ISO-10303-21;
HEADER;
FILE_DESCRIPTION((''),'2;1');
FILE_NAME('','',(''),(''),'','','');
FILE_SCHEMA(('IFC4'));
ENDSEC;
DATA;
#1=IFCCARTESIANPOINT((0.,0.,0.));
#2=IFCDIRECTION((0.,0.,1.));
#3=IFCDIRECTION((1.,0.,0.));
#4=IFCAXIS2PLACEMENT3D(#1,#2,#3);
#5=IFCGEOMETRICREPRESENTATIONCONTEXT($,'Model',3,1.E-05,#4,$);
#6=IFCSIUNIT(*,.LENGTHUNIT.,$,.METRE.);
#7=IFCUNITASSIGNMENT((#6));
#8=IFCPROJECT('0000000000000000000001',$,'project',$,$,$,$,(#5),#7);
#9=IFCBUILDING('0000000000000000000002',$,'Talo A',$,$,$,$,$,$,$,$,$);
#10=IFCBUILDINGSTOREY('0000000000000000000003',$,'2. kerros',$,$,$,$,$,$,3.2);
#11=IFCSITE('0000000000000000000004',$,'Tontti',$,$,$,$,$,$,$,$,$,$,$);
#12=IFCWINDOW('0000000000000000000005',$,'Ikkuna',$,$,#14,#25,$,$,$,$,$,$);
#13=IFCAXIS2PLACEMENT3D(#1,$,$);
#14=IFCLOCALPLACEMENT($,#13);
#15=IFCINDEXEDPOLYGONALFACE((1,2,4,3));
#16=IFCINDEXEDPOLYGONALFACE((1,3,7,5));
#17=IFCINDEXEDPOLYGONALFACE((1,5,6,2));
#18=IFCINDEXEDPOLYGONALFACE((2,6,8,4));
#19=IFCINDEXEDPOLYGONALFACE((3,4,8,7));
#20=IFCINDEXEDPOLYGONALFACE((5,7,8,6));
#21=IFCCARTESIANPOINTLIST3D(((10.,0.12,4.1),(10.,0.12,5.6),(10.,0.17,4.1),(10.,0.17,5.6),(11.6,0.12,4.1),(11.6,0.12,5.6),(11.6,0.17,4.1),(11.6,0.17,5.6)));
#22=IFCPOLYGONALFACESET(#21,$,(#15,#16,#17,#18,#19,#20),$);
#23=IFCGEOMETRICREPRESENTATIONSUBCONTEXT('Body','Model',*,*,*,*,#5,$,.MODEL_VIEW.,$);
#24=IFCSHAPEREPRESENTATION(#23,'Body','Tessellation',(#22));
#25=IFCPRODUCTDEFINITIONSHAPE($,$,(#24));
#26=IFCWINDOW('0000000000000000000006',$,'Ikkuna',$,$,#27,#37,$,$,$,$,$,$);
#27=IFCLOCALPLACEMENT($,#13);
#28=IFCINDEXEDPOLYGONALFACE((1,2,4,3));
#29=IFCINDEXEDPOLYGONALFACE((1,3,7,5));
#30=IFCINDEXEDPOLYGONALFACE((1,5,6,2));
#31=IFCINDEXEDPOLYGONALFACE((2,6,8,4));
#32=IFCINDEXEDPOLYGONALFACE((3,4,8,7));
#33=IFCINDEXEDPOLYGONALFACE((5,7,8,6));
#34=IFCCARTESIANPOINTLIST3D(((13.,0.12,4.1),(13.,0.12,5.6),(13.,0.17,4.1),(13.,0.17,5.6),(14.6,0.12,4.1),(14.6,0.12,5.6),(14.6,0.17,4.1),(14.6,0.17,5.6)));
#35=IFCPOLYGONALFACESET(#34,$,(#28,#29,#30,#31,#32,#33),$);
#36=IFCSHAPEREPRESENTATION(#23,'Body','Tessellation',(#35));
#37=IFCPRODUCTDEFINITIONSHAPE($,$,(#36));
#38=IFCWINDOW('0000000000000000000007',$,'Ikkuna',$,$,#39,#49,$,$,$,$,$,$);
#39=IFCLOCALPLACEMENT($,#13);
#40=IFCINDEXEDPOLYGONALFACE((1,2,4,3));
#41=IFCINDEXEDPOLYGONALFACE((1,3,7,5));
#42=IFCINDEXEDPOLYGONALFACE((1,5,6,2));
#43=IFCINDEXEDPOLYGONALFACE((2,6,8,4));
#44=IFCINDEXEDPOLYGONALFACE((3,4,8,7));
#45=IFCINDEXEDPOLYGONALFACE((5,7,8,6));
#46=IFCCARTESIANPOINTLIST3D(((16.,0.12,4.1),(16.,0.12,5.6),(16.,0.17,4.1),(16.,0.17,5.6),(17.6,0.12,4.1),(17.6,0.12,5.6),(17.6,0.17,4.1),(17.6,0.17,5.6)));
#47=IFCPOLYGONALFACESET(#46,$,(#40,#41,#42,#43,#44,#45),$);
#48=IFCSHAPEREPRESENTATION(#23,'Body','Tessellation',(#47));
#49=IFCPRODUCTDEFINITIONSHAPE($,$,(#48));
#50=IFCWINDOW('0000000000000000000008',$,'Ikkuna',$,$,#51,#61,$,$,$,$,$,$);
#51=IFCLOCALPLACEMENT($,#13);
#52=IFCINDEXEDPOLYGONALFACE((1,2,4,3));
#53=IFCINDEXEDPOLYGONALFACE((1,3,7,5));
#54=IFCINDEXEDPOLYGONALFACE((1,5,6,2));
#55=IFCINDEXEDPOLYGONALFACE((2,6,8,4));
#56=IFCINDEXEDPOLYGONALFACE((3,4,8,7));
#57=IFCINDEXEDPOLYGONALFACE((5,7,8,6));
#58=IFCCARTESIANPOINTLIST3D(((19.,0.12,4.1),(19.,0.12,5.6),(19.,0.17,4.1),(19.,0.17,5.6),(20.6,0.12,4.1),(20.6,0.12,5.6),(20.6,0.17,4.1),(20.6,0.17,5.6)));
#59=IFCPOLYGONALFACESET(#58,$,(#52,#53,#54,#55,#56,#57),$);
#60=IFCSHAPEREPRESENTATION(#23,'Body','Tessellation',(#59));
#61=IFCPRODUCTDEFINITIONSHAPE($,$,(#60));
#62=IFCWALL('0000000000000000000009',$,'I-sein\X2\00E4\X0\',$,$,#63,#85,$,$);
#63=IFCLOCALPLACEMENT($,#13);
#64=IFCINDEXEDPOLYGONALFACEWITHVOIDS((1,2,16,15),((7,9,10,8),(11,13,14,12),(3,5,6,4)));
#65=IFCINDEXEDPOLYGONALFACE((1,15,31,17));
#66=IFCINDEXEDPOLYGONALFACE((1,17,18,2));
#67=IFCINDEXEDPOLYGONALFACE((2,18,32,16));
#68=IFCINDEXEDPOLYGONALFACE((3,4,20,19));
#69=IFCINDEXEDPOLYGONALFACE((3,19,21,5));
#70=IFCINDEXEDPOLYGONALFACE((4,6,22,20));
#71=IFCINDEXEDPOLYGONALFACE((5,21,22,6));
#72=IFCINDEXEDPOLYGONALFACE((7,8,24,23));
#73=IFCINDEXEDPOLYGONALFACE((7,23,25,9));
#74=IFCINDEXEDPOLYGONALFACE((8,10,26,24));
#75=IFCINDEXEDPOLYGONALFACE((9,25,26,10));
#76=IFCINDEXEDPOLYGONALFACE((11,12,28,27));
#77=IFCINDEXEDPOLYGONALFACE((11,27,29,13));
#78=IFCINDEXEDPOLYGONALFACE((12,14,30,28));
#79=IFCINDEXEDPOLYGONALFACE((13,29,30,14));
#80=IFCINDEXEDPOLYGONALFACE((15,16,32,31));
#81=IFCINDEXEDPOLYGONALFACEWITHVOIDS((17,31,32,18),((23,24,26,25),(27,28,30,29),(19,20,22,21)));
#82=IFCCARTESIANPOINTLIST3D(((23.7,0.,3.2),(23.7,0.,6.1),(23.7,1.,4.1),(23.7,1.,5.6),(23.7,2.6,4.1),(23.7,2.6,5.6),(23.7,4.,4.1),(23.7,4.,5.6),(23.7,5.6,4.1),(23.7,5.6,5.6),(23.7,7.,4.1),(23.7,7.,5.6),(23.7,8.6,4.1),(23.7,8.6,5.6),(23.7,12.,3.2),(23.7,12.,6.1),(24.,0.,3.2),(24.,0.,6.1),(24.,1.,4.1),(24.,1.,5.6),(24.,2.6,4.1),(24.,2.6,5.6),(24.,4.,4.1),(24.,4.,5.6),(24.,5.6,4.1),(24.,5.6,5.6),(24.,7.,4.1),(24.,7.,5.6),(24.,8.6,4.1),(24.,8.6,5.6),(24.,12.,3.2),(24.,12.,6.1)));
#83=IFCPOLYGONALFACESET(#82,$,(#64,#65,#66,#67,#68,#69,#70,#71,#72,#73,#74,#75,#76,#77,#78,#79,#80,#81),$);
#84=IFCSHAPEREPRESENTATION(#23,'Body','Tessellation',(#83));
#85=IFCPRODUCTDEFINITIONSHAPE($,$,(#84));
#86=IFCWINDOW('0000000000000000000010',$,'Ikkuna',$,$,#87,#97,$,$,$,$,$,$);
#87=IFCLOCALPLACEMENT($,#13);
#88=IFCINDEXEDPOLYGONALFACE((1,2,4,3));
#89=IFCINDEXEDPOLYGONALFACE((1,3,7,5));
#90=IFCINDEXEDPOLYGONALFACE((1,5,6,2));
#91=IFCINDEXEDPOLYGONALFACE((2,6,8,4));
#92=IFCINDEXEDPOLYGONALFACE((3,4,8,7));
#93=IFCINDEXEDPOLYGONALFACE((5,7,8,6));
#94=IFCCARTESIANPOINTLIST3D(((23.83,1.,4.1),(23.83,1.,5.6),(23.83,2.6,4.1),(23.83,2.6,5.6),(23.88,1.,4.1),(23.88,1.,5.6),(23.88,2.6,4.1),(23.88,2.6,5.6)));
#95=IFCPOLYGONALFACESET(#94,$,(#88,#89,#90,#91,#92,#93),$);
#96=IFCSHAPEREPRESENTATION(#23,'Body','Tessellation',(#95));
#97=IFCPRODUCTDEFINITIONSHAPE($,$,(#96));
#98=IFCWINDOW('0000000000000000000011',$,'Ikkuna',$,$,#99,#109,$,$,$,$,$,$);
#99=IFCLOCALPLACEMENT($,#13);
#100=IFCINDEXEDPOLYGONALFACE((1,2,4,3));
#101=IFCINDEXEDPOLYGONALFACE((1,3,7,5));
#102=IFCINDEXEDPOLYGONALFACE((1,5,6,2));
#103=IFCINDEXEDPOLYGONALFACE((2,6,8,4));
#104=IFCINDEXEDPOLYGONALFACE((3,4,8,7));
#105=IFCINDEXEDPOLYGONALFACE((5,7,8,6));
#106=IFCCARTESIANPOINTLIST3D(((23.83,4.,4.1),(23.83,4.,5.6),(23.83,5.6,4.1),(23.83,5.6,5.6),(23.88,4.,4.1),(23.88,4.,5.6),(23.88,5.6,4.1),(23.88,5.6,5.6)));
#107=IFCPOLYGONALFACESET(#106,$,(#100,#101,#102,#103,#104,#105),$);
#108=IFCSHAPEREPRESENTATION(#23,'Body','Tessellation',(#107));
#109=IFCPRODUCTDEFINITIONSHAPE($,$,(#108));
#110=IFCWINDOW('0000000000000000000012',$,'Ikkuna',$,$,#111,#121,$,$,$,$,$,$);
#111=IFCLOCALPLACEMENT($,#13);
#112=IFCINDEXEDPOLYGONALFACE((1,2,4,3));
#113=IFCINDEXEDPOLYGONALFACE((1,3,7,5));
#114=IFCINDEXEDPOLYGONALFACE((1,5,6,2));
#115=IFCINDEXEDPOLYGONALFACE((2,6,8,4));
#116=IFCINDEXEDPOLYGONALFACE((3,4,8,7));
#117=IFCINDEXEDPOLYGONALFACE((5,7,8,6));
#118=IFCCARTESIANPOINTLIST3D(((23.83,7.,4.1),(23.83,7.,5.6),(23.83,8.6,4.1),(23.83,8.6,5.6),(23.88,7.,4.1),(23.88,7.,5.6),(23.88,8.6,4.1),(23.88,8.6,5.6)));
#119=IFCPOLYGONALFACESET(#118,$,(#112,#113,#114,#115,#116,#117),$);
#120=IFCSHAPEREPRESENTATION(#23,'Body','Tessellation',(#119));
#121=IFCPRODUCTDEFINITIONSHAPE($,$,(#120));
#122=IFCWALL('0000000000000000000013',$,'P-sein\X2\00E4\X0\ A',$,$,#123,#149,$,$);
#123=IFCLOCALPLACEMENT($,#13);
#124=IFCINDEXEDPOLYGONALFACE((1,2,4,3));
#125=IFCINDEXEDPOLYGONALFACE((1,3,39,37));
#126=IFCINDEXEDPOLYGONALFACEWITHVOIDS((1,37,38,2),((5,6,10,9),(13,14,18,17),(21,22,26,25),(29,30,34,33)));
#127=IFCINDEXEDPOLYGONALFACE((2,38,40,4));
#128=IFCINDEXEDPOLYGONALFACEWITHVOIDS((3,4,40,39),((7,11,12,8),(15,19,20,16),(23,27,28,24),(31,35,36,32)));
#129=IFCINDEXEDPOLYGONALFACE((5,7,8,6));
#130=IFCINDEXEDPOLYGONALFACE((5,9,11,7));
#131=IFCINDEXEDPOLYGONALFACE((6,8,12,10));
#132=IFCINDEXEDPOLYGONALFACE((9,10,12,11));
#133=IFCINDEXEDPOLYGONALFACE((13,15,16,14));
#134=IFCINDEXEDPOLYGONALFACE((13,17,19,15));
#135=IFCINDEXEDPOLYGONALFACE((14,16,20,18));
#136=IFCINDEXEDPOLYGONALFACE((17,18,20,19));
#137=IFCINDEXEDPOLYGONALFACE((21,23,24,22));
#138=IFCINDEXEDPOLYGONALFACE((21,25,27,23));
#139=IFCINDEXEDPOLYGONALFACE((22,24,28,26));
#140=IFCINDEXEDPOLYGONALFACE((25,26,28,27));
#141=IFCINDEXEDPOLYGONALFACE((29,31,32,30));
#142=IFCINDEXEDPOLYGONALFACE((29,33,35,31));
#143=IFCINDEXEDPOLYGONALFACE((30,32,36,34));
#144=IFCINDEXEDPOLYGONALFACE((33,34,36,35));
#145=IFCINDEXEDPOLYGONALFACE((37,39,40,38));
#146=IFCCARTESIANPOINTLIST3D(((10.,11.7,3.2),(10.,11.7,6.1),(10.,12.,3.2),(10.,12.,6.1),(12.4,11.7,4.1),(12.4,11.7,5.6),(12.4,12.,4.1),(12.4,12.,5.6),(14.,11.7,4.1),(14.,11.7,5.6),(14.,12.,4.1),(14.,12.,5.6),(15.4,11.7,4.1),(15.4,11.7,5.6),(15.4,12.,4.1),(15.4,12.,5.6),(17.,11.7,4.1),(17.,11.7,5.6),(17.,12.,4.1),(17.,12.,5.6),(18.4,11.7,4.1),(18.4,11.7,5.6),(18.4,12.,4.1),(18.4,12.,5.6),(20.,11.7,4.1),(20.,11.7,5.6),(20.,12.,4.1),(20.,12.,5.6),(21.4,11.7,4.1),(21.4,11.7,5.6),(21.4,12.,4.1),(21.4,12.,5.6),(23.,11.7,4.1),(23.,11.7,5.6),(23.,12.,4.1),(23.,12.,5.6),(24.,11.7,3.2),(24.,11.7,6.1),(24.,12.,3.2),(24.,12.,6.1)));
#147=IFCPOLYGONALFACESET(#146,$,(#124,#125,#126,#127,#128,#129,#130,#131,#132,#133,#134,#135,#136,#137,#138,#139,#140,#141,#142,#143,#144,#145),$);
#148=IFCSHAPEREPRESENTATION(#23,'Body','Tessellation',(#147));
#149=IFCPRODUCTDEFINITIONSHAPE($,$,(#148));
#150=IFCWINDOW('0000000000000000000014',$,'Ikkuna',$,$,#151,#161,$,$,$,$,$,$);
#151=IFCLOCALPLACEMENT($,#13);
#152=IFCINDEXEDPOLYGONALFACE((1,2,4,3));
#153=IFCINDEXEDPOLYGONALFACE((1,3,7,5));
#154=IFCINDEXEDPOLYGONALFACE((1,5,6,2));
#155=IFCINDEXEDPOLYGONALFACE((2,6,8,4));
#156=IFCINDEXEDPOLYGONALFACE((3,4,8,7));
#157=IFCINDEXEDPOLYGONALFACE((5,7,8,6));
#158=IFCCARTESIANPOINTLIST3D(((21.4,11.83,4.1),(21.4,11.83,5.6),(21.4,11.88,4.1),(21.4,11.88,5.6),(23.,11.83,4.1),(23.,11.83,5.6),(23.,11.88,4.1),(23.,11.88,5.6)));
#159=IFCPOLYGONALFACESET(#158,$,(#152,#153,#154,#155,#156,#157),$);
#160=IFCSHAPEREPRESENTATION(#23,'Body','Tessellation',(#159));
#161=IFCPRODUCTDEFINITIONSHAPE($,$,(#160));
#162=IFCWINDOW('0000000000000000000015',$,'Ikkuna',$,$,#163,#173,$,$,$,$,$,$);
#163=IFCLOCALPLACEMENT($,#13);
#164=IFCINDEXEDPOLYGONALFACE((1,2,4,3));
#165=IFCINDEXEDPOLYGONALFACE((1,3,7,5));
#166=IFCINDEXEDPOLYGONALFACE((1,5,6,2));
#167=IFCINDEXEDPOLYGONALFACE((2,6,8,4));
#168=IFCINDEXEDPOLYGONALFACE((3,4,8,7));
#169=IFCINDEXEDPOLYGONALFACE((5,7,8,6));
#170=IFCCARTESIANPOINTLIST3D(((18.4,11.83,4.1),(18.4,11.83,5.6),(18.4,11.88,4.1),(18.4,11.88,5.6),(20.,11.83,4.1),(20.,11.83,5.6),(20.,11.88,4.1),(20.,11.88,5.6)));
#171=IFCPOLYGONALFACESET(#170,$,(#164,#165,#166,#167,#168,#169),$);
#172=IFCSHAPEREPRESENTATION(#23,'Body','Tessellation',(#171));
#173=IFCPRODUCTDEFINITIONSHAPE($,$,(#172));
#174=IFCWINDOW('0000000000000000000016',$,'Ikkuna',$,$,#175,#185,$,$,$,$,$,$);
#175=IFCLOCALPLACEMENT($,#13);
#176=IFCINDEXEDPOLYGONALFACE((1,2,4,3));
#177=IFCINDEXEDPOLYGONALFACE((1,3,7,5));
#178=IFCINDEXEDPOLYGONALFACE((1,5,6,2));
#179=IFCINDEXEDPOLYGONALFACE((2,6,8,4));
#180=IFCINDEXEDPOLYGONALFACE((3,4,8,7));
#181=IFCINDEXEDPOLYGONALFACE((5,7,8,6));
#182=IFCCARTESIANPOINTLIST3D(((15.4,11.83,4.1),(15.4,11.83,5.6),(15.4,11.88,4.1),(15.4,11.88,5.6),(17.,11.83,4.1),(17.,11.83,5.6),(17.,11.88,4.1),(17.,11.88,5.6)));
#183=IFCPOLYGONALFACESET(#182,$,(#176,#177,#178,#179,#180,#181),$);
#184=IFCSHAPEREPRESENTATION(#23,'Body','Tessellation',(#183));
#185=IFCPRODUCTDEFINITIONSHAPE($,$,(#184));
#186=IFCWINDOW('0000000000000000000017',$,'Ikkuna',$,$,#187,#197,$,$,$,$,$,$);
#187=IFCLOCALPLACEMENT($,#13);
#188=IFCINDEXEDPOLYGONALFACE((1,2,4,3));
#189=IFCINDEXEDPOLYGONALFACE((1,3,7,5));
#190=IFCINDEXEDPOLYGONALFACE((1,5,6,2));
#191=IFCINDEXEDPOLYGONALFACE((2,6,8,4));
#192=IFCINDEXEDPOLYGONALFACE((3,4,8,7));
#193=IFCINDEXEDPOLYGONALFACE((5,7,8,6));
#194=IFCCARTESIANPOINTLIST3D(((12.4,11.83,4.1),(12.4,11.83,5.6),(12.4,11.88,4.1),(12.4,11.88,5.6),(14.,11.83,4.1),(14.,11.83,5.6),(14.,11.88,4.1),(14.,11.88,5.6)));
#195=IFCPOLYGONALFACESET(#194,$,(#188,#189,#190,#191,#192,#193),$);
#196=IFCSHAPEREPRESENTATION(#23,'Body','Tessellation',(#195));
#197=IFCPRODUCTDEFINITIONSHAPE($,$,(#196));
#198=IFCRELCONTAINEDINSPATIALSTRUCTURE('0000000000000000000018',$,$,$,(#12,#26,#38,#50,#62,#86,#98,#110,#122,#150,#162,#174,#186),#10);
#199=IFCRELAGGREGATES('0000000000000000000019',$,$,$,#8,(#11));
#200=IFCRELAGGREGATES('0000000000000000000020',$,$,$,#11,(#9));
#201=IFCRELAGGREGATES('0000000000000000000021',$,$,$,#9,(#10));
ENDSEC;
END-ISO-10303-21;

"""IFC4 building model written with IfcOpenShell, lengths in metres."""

from ifc_helpers import new_model, si_unit, frame, origin_with_axes, place, context, subcontext, project, spatial, indexed_curve, outline, extrude, element, save


model = new_model("IFC4")

# Units and contexts
model_context = context("Model", 3, precision=1e-05, world=origin_with_axes())
body_context = subcontext(model_context, "Body", "Model", "MODEL_VIEW")
ifc_project = project(units=[si_unit("LENGTHUNIT", "METRE")], contexts=[model_context])

# Site, building, storey
site = spatial("IfcSite", under=ifc_project, Name="Tontti")
building = spatial("IfcBuilding", under=site, Name="Talo A")
storey = spatial("IfcBuildingStorey", under=building, Name="2. kerros", Elevation=3.2)

# Windows
for number, where, z_axis, x_axis, name in (
    (1, (10.0, 0.12, 4.1), (0.0, 0.0, 1.0), (1.0, 0.0, 0.0), "Ikkuna"),
    (2, (13.0, 0.12, 4.1), (0.0, 0.0, 1.0), (1.0, 0.0, 0.0), "Ikkuna"),
    (3, (16.0, 0.12, 4.1), (0.0, 0.0, 1.0), (1.0, 0.0, 0.0), "Ikkuna"),
    (4, (19.0, 0.12, 4.1), (0.0, 0.0, 1.0), (1.0, 0.0, 0.0), "Ikkuna"),
):
    element("IfcWindow", number, at=place(None, frame(where, z_axis=z_axis, x_axis=x_axis)), inside=storey, Name=name, context=body_context, shape_type="SweptSolid", body=[
        extrude(outline(indexed_curve([(0.0, 0.0), (0.0, 0.05), (1.6, 0.05), (1.6, 0.0), (0.0, 0.0)], self_intersect=False)), origin_with_axes(), (0.0, 0.0, 1.0), 1.5),
    ])

# Wall, openings
wall_1_placement = place(None, frame((24.0, 0.0, 3.2), z_axis=(0.0, 0.0, 1.0), x_axis=(0.0, 1.0, 0.0)))
wall_1 = element("IfcWall", 5, at=wall_1_placement, inside=storey, Name="I-seinä", context=body_context, shape_type="SweptSolid", body=[
    extrude(outline(indexed_curve([(0.0, 0.0), (0.0, 0.3), (12.0, 0.3), (12.0, 0.0), (0.0, 0.0)], self_intersect=False)), origin_with_axes(), (0.0, 0.0, 1.0), 2.9),
])
opening_1_placement = place(wall_1_placement, frame((1.0, -0.1, 0.9), z_axis=(0.0, 0.0, 1.0), x_axis=(1.0, 0.0, 0.0)))
element("IfcOpeningElement", 6, at=opening_1_placement, cuts=wall_1, context=body_context, shape_type="SweptSolid", body=[
    extrude(outline(indexed_curve([(0.0, 0.0), (0.0, 0.5), (1.6, 0.5), (1.6, 0.0), (0.0, 0.0)], self_intersect=False)), origin_with_axes(), (0.0, 0.0, 1.0), 1.5),
])
opening_2_placement = place(wall_1_placement, frame((4.0, -0.1, 0.9), z_axis=(0.0, 0.0, 1.0), x_axis=(1.0, 0.0, 0.0)))
element("IfcOpeningElement", 7, at=opening_2_placement, cuts=wall_1, context=body_context, shape_type="SweptSolid", body=[
    extrude(outline(indexed_curve([(0.0, 0.0), (0.0, 0.5), (1.6, 0.5), (1.6, 0.0), (0.0, 0.0)], self_intersect=False)), origin_with_axes(), (0.0, 0.0, 1.0), 1.5),
])
opening_3_placement = place(wall_1_placement, frame((7.0, -0.1, 0.9), z_axis=(0.0, 0.0, 1.0), x_axis=(1.0, 0.0, 0.0)))
element("IfcOpeningElement", 8, at=opening_3_placement, cuts=wall_1, context=body_context, shape_type="SweptSolid", body=[
    extrude(outline(indexed_curve([(0.0, 0.0), (0.0, 0.5), (1.6, 0.5), (1.6, 0.0), (0.0, 0.0)], self_intersect=False)), origin_with_axes(), (0.0, 0.0, 1.0), 1.5),
])

# Windows
for number, where, z_axis, x_axis, name in (
    (9, (23.88, 1.0, 4.1), (0.0, 0.0, 1.0), (0.0, 1.0, 0.0), "Ikkuna"),
    (10, (23.88, 4.0, 4.1), (0.0, 0.0, 1.0), (0.0, 1.0, 0.0), "Ikkuna"),
    (11, (23.88, 7.0, 4.1), (0.0, 0.0, 1.0), (0.0, 1.0, 0.0), "Ikkuna"),
):
    element("IfcWindow", number, at=place(None, frame(where, z_axis=z_axis, x_axis=x_axis)), inside=storey, Name=name, context=body_context, shape_type="SweptSolid", body=[
        extrude(outline(indexed_curve([(0.0, 0.0), (0.0, 0.05), (1.6, 0.05), (1.6, 0.0), (0.0, 0.0)], self_intersect=False)), origin_with_axes(), (0.0, 0.0, 1.0), 1.5),
    ])

# Wall, openings
wall_2_placement = place(None, frame((24.0, 12.0, 3.2), z_axis=(0.0, 0.0, 1.0), x_axis=(-1.0, 0.0, 0.0)))
wall_2 = element("IfcWall", 12, at=wall_2_placement, inside=storey, Name="P-seinä A", context=body_context, shape_type="SweptSolid", body=[
    extrude(outline(indexed_curve([(0.0, 0.0), (0.0, 0.3), (14.0, 0.3), (14.0, 0.0), (0.0, 0.0)], self_intersect=False)), origin_with_axes(), (0.0, 0.0, 1.0), 2.9),
])
opening_4_placement = place(wall_2_placement, frame((1.0, -0.1, 0.9), z_axis=(0.0, 0.0, 1.0), x_axis=(1.0, 0.0, 0.0)))
element("IfcOpeningElement", 13, at=opening_4_placement, cuts=wall_2, context=body_context, shape_type="SweptSolid", body=[
    extrude(outline(indexed_curve([(0.0, 0.0), (0.0, 0.5), (1.6, 0.5), (1.6, 0.0), (0.0, 0.0)], self_intersect=False)), origin_with_axes(), (0.0, 0.0, 1.0), 1.5),
])
opening_5_placement = place(wall_2_placement, frame((4.0, -0.1, 0.9), z_axis=(0.0, 0.0, 1.0), x_axis=(1.0, 0.0, 0.0)))
element("IfcOpeningElement", 14, at=opening_5_placement, cuts=wall_2, context=body_context, shape_type="SweptSolid", body=[
    extrude(outline(indexed_curve([(0.0, 0.0), (0.0, 0.5), (1.6, 0.5), (1.6, 0.0), (0.0, 0.0)], self_intersect=False)), origin_with_axes(), (0.0, 0.0, 1.0), 1.5),
])
opening_6_placement = place(wall_2_placement, frame((7.0, -0.1, 0.9), z_axis=(0.0, 0.0, 1.0), x_axis=(1.0, 0.0, 0.0)))
element("IfcOpeningElement", 15, at=opening_6_placement, cuts=wall_2, context=body_context, shape_type="SweptSolid", body=[
    extrude(outline(indexed_curve([(0.0, 0.0), (0.0, 0.5), (1.6, 0.5), (1.6, 0.0), (0.0, 0.0)], self_intersect=False)), origin_with_axes(), (0.0, 0.0, 1.0), 1.5),
])
opening_7_placement = place(wall_2_placement, frame((10.0, -0.1, 0.9), z_axis=(0.0, 0.0, 1.0), x_axis=(1.0, 0.0, 0.0)))
element("IfcOpeningElement", 16, at=opening_7_placement, cuts=wall_2, context=body_context, shape_type="SweptSolid", body=[
    extrude(outline(indexed_curve([(0.0, 0.0), (0.0, 0.5), (1.6, 0.5), (1.6, 0.0), (0.0, 0.0)], self_intersect=False)), origin_with_axes(), (0.0, 0.0, 1.0), 1.5),
])

# Windows
for number, where, z_axis, x_axis, name in (
    (17, (23.0, 11.88, 4.1), (0.0, 0.0, 1.0), (-1.0, 0.0, 0.0), "Ikkuna"),
    (18, (20.0, 11.88, 4.1), (0.0, 0.0, 1.0), (-1.0, 0.0, 0.0), "Ikkuna"),
    (19, (17.0, 11.88, 4.1), (0.0, 0.0, 1.0), (-1.0, 0.0, 0.0), "Ikkuna"),
    (20, (14.0, 11.88, 4.1), (0.0, 0.0, 1.0), (-1.0, 0.0, 0.0), "Ikkuna"),
):
    element("IfcWindow", number, at=place(None, frame(where, z_axis=z_axis, x_axis=x_axis)), inside=storey, Name=name, context=body_context, shape_type="SweptSolid", body=[
        extrude(outline(indexed_curve([(0.0, 0.0), (0.0, 0.05), (1.6, 0.05), (1.6, 0.0), (0.0, 0.0)], self_intersect=False)), origin_with_axes(), (0.0, 0.0, 1.0), 1.5),
    ])

save(model, "model.ifc")
